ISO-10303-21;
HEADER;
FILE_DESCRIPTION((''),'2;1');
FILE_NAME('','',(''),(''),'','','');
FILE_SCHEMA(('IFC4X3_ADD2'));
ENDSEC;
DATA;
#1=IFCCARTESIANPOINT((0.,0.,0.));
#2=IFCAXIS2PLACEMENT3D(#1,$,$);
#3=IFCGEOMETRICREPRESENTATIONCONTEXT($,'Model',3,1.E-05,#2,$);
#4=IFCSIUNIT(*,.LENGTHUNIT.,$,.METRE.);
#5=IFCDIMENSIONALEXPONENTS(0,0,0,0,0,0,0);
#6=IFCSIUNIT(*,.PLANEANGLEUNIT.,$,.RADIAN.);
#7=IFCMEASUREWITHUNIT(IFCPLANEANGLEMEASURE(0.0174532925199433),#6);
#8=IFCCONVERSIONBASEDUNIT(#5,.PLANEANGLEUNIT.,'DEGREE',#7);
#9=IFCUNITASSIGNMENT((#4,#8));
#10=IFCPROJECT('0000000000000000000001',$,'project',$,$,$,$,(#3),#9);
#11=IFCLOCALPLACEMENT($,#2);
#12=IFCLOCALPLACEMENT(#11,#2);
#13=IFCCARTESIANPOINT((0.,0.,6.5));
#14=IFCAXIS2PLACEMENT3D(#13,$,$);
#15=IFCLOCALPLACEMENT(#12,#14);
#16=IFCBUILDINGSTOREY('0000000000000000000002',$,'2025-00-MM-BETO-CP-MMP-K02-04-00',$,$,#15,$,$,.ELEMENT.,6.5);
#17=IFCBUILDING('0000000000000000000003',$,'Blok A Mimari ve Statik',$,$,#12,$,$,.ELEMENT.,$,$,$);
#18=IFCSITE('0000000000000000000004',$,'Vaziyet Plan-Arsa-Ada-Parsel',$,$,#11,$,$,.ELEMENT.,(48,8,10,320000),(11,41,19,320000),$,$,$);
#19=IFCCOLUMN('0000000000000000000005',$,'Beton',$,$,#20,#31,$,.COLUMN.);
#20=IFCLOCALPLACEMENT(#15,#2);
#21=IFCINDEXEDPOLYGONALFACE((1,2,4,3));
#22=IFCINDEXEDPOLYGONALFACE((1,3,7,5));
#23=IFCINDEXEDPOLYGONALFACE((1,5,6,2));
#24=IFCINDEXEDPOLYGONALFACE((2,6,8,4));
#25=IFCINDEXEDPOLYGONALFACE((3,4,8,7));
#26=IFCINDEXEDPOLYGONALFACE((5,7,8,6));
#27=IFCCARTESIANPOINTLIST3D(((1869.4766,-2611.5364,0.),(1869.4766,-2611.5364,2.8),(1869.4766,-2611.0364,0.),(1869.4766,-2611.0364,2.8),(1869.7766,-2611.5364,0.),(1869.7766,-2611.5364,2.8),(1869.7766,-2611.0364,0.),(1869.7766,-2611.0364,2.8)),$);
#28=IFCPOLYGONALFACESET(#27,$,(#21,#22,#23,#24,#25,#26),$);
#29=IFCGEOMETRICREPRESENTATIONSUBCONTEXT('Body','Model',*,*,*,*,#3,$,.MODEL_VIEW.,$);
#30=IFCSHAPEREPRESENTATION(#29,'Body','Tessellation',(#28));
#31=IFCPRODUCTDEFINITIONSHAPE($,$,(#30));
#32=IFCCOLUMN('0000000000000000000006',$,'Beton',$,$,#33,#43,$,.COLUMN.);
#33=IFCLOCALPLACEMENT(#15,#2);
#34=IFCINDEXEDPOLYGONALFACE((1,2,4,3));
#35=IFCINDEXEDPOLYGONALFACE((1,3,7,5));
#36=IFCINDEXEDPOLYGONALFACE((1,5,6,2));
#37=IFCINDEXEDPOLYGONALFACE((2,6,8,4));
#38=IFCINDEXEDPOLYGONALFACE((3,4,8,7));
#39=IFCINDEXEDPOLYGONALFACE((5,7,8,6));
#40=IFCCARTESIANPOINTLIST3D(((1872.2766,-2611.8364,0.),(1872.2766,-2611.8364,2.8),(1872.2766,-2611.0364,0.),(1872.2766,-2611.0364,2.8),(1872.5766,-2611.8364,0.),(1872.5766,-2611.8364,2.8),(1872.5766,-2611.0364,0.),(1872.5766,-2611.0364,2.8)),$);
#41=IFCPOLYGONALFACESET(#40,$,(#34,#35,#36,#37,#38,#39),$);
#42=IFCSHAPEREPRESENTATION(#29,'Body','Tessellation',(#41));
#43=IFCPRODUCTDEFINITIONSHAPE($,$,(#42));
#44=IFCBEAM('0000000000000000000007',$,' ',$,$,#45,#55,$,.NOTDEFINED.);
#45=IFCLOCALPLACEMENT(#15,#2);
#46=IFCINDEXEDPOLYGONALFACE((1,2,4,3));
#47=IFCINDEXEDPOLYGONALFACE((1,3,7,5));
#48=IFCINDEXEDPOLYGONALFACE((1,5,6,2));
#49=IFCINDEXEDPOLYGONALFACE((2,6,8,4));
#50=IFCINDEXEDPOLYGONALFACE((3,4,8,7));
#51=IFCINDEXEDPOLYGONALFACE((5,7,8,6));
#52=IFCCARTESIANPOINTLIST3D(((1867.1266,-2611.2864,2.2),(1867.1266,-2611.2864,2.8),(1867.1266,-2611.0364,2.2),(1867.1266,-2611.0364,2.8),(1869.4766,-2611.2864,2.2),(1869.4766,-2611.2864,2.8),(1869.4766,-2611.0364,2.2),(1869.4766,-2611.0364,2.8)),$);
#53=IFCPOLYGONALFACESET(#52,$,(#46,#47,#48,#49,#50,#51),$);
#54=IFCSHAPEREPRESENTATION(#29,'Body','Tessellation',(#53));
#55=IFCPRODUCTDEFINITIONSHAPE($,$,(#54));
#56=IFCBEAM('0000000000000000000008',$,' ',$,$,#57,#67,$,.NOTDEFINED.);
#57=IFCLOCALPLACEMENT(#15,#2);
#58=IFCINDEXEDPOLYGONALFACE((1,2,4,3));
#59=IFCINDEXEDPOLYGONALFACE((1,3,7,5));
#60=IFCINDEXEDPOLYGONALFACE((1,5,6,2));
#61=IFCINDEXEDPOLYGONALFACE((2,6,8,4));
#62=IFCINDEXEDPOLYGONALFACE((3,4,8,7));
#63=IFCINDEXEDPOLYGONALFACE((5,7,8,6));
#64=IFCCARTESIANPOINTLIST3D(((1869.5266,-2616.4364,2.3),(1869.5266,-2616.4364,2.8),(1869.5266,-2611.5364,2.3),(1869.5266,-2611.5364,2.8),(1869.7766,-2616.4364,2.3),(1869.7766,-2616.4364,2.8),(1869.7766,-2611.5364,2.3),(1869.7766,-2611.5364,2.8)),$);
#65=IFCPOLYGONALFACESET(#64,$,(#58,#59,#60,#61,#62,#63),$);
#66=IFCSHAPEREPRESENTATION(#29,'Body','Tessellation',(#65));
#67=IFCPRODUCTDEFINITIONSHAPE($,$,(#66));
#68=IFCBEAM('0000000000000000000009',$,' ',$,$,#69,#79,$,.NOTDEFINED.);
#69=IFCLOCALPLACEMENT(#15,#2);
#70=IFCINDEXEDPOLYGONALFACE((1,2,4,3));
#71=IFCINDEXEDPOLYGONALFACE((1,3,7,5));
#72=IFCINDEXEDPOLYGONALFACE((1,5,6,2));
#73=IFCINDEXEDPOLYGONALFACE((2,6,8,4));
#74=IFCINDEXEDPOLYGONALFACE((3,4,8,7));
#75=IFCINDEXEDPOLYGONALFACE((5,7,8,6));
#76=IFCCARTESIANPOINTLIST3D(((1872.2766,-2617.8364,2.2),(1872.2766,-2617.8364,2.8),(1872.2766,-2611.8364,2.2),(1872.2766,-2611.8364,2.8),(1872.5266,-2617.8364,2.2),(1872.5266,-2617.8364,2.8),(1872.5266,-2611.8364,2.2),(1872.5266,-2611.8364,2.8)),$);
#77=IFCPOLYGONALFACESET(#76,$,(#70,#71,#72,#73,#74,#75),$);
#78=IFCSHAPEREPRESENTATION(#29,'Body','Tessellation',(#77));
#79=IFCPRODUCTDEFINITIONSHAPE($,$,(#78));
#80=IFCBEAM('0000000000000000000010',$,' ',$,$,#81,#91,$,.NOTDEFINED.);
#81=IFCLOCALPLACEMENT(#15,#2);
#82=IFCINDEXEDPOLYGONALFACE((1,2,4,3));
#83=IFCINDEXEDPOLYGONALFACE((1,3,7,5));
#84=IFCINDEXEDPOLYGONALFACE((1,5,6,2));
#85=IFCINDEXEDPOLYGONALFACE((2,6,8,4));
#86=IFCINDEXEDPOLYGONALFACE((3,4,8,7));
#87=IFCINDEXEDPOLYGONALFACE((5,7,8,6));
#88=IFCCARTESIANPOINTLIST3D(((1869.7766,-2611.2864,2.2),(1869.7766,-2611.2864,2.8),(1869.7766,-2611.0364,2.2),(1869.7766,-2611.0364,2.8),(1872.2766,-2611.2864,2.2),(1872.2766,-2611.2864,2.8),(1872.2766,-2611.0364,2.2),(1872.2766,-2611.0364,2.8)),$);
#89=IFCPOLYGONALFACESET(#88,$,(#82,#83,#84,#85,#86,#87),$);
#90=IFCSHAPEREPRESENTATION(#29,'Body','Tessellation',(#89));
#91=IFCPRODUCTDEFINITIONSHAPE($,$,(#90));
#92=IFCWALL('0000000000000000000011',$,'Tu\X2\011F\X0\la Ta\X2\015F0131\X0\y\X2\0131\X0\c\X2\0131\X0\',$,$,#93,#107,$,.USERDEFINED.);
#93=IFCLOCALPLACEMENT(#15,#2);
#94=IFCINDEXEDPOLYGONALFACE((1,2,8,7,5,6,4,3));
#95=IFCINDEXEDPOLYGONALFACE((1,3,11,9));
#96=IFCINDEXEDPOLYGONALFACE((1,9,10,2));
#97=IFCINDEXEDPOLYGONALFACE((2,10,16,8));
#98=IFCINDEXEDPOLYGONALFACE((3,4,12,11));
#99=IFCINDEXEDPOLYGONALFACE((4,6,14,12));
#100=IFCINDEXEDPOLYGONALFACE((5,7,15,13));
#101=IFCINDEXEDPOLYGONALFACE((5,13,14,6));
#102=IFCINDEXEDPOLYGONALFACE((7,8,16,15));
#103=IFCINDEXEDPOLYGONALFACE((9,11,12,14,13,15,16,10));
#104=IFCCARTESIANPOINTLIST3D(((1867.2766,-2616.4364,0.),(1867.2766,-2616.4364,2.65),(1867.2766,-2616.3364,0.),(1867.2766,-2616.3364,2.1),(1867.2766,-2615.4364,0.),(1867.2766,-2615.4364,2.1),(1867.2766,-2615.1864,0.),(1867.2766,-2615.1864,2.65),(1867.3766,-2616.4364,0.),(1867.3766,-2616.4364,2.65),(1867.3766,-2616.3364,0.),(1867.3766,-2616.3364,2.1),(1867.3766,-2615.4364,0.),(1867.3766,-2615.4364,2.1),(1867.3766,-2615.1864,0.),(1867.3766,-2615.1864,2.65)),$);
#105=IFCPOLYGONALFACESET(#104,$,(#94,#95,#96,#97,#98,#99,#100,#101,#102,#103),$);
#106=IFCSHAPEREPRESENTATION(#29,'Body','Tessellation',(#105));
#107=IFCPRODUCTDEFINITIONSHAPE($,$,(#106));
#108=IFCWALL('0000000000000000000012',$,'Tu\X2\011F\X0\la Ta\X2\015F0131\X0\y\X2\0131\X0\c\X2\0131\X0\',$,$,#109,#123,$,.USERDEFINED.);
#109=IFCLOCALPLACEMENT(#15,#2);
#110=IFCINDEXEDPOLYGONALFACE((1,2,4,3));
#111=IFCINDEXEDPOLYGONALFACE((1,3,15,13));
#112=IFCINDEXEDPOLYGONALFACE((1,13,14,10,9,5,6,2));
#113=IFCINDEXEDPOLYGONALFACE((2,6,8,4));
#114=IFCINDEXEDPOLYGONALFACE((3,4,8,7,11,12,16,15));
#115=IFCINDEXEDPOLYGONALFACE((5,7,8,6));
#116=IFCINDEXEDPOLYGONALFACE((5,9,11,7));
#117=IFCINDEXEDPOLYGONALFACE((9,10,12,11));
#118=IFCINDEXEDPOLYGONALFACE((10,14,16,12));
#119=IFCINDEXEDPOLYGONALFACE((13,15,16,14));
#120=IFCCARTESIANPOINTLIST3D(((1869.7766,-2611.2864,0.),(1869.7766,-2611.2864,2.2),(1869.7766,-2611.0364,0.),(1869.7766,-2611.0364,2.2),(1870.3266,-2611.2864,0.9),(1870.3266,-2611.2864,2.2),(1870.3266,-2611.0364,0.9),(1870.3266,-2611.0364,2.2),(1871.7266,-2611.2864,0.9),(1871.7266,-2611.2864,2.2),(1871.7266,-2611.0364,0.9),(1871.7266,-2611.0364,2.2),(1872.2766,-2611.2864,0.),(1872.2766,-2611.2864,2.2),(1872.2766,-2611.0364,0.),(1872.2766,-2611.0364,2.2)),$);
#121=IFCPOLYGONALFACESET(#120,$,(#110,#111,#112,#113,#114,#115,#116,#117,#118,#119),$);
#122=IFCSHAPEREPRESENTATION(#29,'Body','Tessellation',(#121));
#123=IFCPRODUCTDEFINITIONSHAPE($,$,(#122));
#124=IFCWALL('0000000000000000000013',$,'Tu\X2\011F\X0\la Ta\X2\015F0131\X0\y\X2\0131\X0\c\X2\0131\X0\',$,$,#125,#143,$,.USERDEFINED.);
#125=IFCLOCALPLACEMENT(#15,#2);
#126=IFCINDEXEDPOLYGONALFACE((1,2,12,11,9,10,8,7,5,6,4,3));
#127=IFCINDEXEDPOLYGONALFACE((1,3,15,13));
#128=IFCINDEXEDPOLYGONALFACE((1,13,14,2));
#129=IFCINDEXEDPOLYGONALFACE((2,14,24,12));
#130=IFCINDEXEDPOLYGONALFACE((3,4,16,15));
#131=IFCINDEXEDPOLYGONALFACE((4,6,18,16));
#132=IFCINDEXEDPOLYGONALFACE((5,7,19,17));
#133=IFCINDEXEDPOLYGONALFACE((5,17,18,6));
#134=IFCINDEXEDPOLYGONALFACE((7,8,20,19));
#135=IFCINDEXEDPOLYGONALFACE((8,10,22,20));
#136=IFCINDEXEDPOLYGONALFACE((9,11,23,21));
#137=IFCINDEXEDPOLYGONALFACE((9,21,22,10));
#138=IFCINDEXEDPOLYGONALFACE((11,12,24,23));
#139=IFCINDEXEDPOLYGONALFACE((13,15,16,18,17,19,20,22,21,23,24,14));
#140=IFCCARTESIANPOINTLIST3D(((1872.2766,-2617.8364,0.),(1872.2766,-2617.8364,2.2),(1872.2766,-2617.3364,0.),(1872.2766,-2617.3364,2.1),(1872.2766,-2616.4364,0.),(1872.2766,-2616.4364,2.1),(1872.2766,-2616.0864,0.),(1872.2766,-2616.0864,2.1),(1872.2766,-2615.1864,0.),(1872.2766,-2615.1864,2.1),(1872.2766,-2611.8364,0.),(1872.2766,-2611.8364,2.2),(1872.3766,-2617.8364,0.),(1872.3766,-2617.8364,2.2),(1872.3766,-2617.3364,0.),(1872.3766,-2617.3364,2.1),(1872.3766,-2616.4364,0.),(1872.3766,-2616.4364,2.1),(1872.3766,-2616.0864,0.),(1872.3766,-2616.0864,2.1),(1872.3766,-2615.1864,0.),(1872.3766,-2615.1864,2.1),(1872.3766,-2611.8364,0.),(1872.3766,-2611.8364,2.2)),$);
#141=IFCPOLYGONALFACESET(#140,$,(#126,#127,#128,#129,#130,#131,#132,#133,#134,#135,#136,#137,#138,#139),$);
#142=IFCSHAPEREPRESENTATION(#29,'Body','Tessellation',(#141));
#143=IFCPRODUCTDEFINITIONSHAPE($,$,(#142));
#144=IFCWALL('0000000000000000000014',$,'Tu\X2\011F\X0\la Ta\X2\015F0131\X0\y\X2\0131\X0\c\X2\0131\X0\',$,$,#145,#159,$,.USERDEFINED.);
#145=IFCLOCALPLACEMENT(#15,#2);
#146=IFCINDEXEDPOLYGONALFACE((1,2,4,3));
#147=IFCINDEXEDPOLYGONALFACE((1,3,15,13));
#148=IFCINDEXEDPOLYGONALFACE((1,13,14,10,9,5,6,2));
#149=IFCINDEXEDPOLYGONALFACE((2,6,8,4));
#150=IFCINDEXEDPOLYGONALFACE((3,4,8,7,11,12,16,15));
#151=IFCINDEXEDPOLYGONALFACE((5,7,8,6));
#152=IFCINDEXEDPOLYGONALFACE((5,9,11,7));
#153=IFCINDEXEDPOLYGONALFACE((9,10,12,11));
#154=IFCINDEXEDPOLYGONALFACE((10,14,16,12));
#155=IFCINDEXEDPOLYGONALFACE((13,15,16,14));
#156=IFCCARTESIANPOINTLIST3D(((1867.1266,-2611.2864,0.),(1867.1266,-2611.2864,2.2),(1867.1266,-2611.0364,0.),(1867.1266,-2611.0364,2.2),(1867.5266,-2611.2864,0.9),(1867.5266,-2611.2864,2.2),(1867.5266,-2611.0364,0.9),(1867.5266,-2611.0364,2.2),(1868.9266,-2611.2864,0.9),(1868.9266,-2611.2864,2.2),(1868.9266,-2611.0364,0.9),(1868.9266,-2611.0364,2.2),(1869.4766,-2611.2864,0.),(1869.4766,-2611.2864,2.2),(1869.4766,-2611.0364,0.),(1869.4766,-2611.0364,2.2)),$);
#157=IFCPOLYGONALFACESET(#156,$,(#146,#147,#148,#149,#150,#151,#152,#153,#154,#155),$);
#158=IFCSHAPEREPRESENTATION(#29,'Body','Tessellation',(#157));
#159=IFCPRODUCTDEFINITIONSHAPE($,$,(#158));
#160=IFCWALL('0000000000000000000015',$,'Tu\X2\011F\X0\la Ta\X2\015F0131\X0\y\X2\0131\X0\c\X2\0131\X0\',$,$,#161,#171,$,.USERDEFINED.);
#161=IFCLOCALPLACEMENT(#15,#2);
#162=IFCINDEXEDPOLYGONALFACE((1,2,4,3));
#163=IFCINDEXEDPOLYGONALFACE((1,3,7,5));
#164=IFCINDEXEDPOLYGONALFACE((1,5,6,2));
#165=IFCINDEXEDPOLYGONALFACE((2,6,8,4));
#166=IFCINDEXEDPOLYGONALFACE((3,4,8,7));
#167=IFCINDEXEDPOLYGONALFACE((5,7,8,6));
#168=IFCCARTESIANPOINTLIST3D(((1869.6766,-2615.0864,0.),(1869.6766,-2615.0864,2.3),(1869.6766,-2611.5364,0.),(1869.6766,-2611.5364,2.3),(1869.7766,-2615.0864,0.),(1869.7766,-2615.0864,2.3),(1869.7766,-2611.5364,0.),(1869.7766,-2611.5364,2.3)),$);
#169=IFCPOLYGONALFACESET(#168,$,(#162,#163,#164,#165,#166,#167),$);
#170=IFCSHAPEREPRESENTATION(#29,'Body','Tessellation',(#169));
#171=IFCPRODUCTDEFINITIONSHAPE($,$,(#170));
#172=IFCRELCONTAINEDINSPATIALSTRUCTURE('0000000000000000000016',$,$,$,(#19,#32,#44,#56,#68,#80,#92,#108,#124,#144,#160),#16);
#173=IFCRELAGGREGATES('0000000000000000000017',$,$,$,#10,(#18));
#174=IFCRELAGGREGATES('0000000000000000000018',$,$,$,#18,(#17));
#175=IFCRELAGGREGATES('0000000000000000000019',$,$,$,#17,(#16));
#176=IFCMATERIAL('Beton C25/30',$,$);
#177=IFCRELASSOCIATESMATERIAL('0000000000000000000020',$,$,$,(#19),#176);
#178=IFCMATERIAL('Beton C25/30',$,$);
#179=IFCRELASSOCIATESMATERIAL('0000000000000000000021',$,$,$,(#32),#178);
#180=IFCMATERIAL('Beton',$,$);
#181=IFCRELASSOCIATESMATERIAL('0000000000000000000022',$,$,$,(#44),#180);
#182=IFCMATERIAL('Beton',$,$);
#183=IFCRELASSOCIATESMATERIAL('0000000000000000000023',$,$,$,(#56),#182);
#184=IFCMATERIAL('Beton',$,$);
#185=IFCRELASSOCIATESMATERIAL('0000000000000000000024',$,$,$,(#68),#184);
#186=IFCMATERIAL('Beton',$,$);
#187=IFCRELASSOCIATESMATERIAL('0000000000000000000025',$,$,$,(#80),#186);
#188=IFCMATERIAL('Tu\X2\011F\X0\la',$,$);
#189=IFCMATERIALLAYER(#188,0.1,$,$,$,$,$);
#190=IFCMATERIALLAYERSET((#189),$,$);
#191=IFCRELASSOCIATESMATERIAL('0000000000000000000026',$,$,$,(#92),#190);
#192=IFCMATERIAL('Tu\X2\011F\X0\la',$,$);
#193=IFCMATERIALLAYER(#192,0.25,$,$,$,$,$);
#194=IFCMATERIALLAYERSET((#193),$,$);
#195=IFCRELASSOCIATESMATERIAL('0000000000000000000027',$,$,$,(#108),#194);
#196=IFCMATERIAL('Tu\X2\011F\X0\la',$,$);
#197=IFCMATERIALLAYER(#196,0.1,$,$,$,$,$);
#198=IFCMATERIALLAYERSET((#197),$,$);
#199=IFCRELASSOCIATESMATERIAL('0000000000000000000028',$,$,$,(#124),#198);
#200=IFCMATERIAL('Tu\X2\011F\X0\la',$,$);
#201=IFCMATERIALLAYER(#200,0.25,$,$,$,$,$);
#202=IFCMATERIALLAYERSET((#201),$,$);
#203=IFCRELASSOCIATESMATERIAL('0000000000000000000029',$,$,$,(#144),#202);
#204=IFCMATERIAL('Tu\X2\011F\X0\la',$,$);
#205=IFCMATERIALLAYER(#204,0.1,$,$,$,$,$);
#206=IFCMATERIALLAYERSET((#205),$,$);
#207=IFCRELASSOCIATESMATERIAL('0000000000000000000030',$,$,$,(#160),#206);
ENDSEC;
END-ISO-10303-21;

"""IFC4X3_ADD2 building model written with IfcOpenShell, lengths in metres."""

from ifc_helpers import new_model, entity, si_unit, converted_unit, frame, frame_2d, origin, origin_with_axes, place, context, subcontext, project, spatial, polyline, rectangle, outline, extrude, material, layer, layer_set, layer_usage, element, save


model = new_model("IFC4X3_ADD2")

# Units and contexts
model_context = context("Model", 3, precision=1e-05, world=origin())
body_context = subcontext(model_context, "Body", "Model", "MODEL_VIEW")
ifc_project = project(units=[si_unit("LENGTHUNIT", "METRE"), converted_unit("PLANEANGLEUNIT", "DEGREE", entity("IfcPlaneAngleMeasure", 0.0174532925199433), si_unit("PLANEANGLEUNIT", "RADIAN"), dimensions=[0, 0, 0, 0, 0, 0, 0])], contexts=[model_context])

# Site, building, storey
site_placement = place(None, origin())
site = spatial("IfcSite", under=ifc_project, at=site_placement, Name="Vaziyet Plan-Arsa-Ada-Parsel", CompositionType="ELEMENT", RefLatitude=(48, 8, 10, 320000), RefLongitude=(11, 41, 19, 320000))
building_placement = place(site_placement, origin())
building = spatial("IfcBuilding", under=site, at=building_placement, Name="Blok A Mimari ve Statik", CompositionType="ELEMENT")
storey_placement = place(building_placement, frame((0.0, 0.0, 6.5)))
storey = spatial("IfcBuildingStorey", under=building, at=storey_placement, Name="2025-00-MM-BETO-CP-MMP-K02-04-00", CompositionType="ELEMENT", Elevation=6.5)

# Columns
ifc_material_1 = material(Name="Beton C25/30")
column_1_placement = place(storey_placement, frame((1869.4766, -2611.5364, 0.0)))
element("IfcColumn", 1, at=column_1_placement, inside=storey, material=ifc_material_1, Name="Beton", PredefinedType="COLUMN", context=body_context, shape_type="SweptSolid", body=[
    extrude(outline(polyline([(0.0, 0.0), (0.3, 0.0), (0.3, 0.5), (0.0, 0.5), (0.0, 0.0)])), origin_with_axes(), (0.0, 0.0, 1.0), 2.8),
])
ifc_material_2 = material(Name="Beton C25/30")
column_2_placement = place(storey_placement, frame((1872.2766, -2611.8364, 0.0)))
element("IfcColumn", 2, at=column_2_placement, inside=storey, material=ifc_material_2, Name="Beton", PredefinedType="COLUMN", context=body_context, shape_type="SweptSolid", body=[
    extrude(outline(polyline([(0.0, 0.0), (0.3, 0.0), (0.3, 0.8), (0.0, 0.8), (0.0, 0.0)])), origin_with_axes(), (0.0, 0.0, 1.0), 2.8),
])

# Beams
ifc_material_3 = material(Name="Beton")
beam_1_placement = place(storey_placement, frame((1869.4766, -2611.0364, 2.2), z_axis=(0.0, 0.0, 1.0), x_axis=(-1.0, 0.0, 0.0)))
element("IfcBeam", 3, at=beam_1_placement, inside=storey, material=ifc_material_3, Name=" ", PredefinedType="NOTDEFINED", context=body_context, shape_type="SweptSolid", body=[
    extrude(rectangle(XDim=0.25, YDim=0.6, at=frame_2d((0.125, 0.3), x_axis=(1.0, 0.0))), frame((0.0, 0.0, 0.0), z_axis=(1.0, 0.0, 0.0), x_axis=(0.0, 1.0, 0.0)), (0.0, 0.0, 1.0), 2.35),
])
ifc_material_4 = material(Name="Beton")
beam_2_placement = place(storey_placement, frame((1869.7766, -2616.4364, 2.3), z_axis=(0.0, 0.0, 1.0), x_axis=(0.0, 1.0, 0.0)))
element("IfcBeam", 4, at=beam_2_placement, inside=storey, material=ifc_material_4, Name=" ", PredefinedType="NOTDEFINED", context=body_context, shape_type="SweptSolid", body=[
    extrude(rectangle(XDim=0.25, YDim=0.5, at=frame_2d((0.125, 0.25), x_axis=(1.0, 0.0))), frame((0.0, 0.0, 0.0), z_axis=(1.0, 0.0, 0.0), x_axis=(0.0, 1.0, 0.0)), (0.0, 0.0, 1.0), 4.9),
])
ifc_material_5 = material(Name="Beton")
beam_3_placement = place(storey_placement, frame((1872.2766, -2611.8364, 2.2), z_axis=(0.0, 0.0, 1.0), x_axis=(0.0, -1.0, 0.0)))
element("IfcBeam", 5, at=beam_3_placement, inside=storey, material=ifc_material_5, Name=" ", PredefinedType="NOTDEFINED", context=body_context, shape_type="SweptSolid", body=[
    extrude(rectangle(XDim=0.25, YDim=0.6, at=frame_2d((0.125, 0.3), x_axis=(1.0, 0.0))), frame((0.0, 0.0, 0.0), z_axis=(1.0, 0.0, 0.0), x_axis=(0.0, 1.0, 0.0)), (0.0, 0.0, 1.0), 6.0),
])
ifc_material_6 = material(Name="Beton")
beam_4_placement = place(storey_placement, frame((1872.2766, -2611.0364, 2.2), z_axis=(0.0, 0.0, 1.0), x_axis=(-1.0, 0.0, 0.0)))
element("IfcBeam", 6, at=beam_4_placement, inside=storey, material=ifc_material_6, Name=" ", PredefinedType="NOTDEFINED", context=body_context, shape_type="SweptSolid", body=[
    extrude(rectangle(XDim=0.25, YDim=0.6, at=frame_2d((0.125, 0.3), x_axis=(1.0, 0.0))), frame((0.0, 0.0, 0.0), z_axis=(1.0, 0.0, 0.0), x_axis=(0.0, 1.0, 0.0)), (0.0, 0.0, 1.0), 2.5),
])

# Wall, opening
ifc_material_7 = material(Name="Tuğla")
ifc_layer_1 = layer(ifc_material_7, 0.1)
ifc_layer_set_1 = layer_set([ifc_layer_1])
ifc_layer_usage_1 = layer_usage(ifc_layer_set_1, "AXIS2", "POSITIVE", 0.0)
wall_1_placement = place(storey_placement, frame((1867.3766, -2616.4364, 0.0), z_axis=(0.0, 0.0, 1.0), x_axis=(0.000001, 1.0, 0.0)))
wall_1 = element("IfcWall", 7, at=wall_1_placement, inside=storey, material=ifc_layer_usage_1, Name="Tuğla Taşıyıcı", PredefinedType="USERDEFINED", context=body_context, shape_type="SweptSolid", body=[
    extrude(rectangle(XDim=1.25, YDim=0.1, at=frame_2d((0.625, 0.05), x_axis=(1.0, 0.0))), origin_with_axes(), (0.0, 0.0, 1.0), 2.65),
])
opening_1_placement = place(wall_1_placement, frame((1.0, 0.1, 0.0), z_axis=(0.0, -1.0, 0.0), x_axis=(0.0, 0.0, 1.0)))
element("IfcOpeningElement", 8, at=opening_1_placement, cuts=wall_1, PredefinedType="OPENING", context=body_context, shape_type="SweptSolid", body=[
    extrude(outline(polyline([(2.1, 0.9), (2.1, 0.0), (0.0, 0.0), (0.0, 0.9), (2.1, 0.9)])), origin_with_axes(), (0.0, 0.0, 1.0), 0.1),
])

# Wall, opening
ifc_material_8 = material(Name="Tuğla")
ifc_layer_2 = layer(ifc_material_8, 0.25)
ifc_layer_set_2 = layer_set([ifc_layer_2])
ifc_layer_usage_2 = layer_usage(ifc_layer_set_2, "AXIS2", "POSITIVE", 0.0)
wall_2_placement = place(storey_placement, frame((1872.2766, -2611.0364, 0.0), z_axis=(0.0, 0.0, 1.0), x_axis=(-1.0, 0.0, 0.0)))
wall_2 = element("IfcWall", 9, at=wall_2_placement, inside=storey, material=ifc_layer_usage_2, Name="Tuğla Taşıyıcı", PredefinedType="USERDEFINED", context=body_context, shape_type="SweptSolid", body=[
    extrude(rectangle(XDim=2.5, YDim=0.25, at=frame_2d((1.25, 0.125), x_axis=(1.0, 0.0))), origin_with_axes(), (0.0, 0.0, 1.0), 2.2),
])
opening_2_placement = place(wall_2_placement, frame((0.55, 0.0, 0.9), z_axis=(0.0, 1.0, 0.0), x_axis=(0.0, 0.0, 1.0)))
element("IfcOpeningElement", 10, at=opening_2_placement, cuts=wall_2, PredefinedType="OPENING", context=body_context, shape_type="SweptSolid", body=[
    extrude(outline(polyline([(1.35, 1.4), (1.35, 0.0), (0.0, 0.0), (0.0, 1.4), (1.35, 1.4)])), origin_with_axes(), (0.0, 0.0, 1.0), 0.25),
])

# Wall, openings
ifc_material_9 = material(Name="Tuğla")
ifc_layer_3 = layer(ifc_material_9, 0.1)
ifc_layer_set_3 = layer_set([ifc_layer_3])
ifc_layer_usage_3 = layer_usage(ifc_layer_set_3, "AXIS2", "POSITIVE", 0.0)
wall_3_placement = place(storey_placement, frame((1872.2766, -2611.8364, 0.0), z_axis=(0.0, 0.0, 1.0), x_axis=(0.0, -1.0, 0.0)))
wall_3 = element("IfcWall", 11, at=wall_3_placement, inside=storey, material=ifc_layer_usage_3, Name="Tuğla Taşıyıcı", PredefinedType="USERDEFINED", context=body_context, shape_type="SweptSolid", body=[
    extrude(outline(polyline([(-6.0, 0.0), (0.0, 0.0), (0.0, 0.1), (-6.0, 0.1), (-6.0, 0.0)])), frame((6.0, 0.0, 0.0), z_axis=(0.0, 0.0, 1.0), x_axis=(1.0, 0.0, 0.0)), (0.0, 0.0, 1.0), 2.2),
])
opening_3_placement = place(wall_3_placement, frame((4.25, 0.1, 0.0), z_axis=(0.0, -1.0, 0.0), x_axis=(0.0, 0.0, 1.0)))
element("IfcOpeningElement", 12, at=opening_3_placement, cuts=wall_3, PredefinedType="OPENING", context=body_context, shape_type="SweptSolid", body=[
    extrude(outline(polyline([(2.1, 0.9), (2.1, 0.0), (0.0, 0.0), (0.0, 0.9), (2.1, 0.9)])), origin_with_axes(), (0.0, 0.0, 1.0), 0.1),
])
opening_4_placement = place(wall_3_placement, frame((4.6, 0.0, 0.0), z_axis=(0.0, 1.0, 0.0), x_axis=(0.0, 0.0, 1.0)))
element("IfcOpeningElement", 13, at=opening_4_placement, cuts=wall_3, PredefinedType="OPENING", context=body_context, shape_type="SweptSolid", body=[
    extrude(outline(polyline([(2.1, 0.9), (2.1, 0.0), (0.0, 0.0), (0.0, 0.9), (2.1, 0.9)])), origin_with_axes(), (0.0, 0.0, 1.0), 0.1),
])

# Wall, opening
ifc_material_10 = material(Name="Tuğla")
ifc_layer_4 = layer(ifc_material_10, 0.25)
ifc_layer_set_4 = layer_set([ifc_layer_4])
ifc_layer_usage_4 = layer_usage(ifc_layer_set_4, "AXIS2", "POSITIVE", 0.0)
wall_4_placement = place(storey_placement, frame((1869.4766, -2611.0364, 0.0), z_axis=(0.0, 0.0, 1.0), x_axis=(-1.0, 0.000001, 0.0)))
wall_4 = element("IfcWall", 14, at=wall_4_placement, inside=storey, material=ifc_layer_usage_4, Name="Tuğla Taşıyıcı", PredefinedType="USERDEFINED", context=body_context, shape_type="SweptSolid", body=[
    extrude(rectangle(XDim=2.35, YDim=0.25, at=frame_2d((1.175, 0.125), x_axis=(1.0, 0.0))), origin_with_axes(), (0.0, 0.0, 1.0), 2.2),
])
opening_5_placement = place(wall_4_placement, frame((0.55, 0.0, 0.9), z_axis=(0.0, 1.0, 0.0), x_axis=(0.0, 0.0, 1.0)))
element("IfcOpeningElement", 15, at=opening_5_placement, cuts=wall_4, PredefinedType="OPENING", context=body_context, shape_type="SweptSolid", body=[
    extrude(outline(polyline([(1.35, 1.4), (1.35, 0.0), (0.0, 0.0), (0.0, 1.4), (1.35, 1.4)])), origin_with_axes(), (0.0, 0.0, 1.0), 0.25),
])

# Wall
ifc_material_11 = material(Name="Tuğla")
ifc_layer_5 = layer(ifc_material_11, 0.1)
ifc_layer_set_5 = layer_set([ifc_layer_5])
ifc_layer_usage_5 = layer_usage(ifc_layer_set_5, "AXIS2", "POSITIVE", 0.0)
wall_5_placement = place(storey_placement, frame((1869.7766, -2615.0864, 0.0), z_axis=(0.0, 0.0, 1.0), x_axis=(0.0, 1.0, 0.0)))
element("IfcWall", 16, at=wall_5_placement, inside=storey, material=ifc_layer_usage_5, Name="Tuğla Taşıyıcı", PredefinedType="USERDEFINED", context=body_context, shape_type="SweptSolid", body=[
    extrude(rectangle(XDim=3.55, YDim=0.1, at=frame_2d((1.775, 0.05), x_axis=(1.0, 0.0))), origin_with_axes(), (0.0, 0.0, 1.0), 2.3),
])

save(model, "model.ifc")
